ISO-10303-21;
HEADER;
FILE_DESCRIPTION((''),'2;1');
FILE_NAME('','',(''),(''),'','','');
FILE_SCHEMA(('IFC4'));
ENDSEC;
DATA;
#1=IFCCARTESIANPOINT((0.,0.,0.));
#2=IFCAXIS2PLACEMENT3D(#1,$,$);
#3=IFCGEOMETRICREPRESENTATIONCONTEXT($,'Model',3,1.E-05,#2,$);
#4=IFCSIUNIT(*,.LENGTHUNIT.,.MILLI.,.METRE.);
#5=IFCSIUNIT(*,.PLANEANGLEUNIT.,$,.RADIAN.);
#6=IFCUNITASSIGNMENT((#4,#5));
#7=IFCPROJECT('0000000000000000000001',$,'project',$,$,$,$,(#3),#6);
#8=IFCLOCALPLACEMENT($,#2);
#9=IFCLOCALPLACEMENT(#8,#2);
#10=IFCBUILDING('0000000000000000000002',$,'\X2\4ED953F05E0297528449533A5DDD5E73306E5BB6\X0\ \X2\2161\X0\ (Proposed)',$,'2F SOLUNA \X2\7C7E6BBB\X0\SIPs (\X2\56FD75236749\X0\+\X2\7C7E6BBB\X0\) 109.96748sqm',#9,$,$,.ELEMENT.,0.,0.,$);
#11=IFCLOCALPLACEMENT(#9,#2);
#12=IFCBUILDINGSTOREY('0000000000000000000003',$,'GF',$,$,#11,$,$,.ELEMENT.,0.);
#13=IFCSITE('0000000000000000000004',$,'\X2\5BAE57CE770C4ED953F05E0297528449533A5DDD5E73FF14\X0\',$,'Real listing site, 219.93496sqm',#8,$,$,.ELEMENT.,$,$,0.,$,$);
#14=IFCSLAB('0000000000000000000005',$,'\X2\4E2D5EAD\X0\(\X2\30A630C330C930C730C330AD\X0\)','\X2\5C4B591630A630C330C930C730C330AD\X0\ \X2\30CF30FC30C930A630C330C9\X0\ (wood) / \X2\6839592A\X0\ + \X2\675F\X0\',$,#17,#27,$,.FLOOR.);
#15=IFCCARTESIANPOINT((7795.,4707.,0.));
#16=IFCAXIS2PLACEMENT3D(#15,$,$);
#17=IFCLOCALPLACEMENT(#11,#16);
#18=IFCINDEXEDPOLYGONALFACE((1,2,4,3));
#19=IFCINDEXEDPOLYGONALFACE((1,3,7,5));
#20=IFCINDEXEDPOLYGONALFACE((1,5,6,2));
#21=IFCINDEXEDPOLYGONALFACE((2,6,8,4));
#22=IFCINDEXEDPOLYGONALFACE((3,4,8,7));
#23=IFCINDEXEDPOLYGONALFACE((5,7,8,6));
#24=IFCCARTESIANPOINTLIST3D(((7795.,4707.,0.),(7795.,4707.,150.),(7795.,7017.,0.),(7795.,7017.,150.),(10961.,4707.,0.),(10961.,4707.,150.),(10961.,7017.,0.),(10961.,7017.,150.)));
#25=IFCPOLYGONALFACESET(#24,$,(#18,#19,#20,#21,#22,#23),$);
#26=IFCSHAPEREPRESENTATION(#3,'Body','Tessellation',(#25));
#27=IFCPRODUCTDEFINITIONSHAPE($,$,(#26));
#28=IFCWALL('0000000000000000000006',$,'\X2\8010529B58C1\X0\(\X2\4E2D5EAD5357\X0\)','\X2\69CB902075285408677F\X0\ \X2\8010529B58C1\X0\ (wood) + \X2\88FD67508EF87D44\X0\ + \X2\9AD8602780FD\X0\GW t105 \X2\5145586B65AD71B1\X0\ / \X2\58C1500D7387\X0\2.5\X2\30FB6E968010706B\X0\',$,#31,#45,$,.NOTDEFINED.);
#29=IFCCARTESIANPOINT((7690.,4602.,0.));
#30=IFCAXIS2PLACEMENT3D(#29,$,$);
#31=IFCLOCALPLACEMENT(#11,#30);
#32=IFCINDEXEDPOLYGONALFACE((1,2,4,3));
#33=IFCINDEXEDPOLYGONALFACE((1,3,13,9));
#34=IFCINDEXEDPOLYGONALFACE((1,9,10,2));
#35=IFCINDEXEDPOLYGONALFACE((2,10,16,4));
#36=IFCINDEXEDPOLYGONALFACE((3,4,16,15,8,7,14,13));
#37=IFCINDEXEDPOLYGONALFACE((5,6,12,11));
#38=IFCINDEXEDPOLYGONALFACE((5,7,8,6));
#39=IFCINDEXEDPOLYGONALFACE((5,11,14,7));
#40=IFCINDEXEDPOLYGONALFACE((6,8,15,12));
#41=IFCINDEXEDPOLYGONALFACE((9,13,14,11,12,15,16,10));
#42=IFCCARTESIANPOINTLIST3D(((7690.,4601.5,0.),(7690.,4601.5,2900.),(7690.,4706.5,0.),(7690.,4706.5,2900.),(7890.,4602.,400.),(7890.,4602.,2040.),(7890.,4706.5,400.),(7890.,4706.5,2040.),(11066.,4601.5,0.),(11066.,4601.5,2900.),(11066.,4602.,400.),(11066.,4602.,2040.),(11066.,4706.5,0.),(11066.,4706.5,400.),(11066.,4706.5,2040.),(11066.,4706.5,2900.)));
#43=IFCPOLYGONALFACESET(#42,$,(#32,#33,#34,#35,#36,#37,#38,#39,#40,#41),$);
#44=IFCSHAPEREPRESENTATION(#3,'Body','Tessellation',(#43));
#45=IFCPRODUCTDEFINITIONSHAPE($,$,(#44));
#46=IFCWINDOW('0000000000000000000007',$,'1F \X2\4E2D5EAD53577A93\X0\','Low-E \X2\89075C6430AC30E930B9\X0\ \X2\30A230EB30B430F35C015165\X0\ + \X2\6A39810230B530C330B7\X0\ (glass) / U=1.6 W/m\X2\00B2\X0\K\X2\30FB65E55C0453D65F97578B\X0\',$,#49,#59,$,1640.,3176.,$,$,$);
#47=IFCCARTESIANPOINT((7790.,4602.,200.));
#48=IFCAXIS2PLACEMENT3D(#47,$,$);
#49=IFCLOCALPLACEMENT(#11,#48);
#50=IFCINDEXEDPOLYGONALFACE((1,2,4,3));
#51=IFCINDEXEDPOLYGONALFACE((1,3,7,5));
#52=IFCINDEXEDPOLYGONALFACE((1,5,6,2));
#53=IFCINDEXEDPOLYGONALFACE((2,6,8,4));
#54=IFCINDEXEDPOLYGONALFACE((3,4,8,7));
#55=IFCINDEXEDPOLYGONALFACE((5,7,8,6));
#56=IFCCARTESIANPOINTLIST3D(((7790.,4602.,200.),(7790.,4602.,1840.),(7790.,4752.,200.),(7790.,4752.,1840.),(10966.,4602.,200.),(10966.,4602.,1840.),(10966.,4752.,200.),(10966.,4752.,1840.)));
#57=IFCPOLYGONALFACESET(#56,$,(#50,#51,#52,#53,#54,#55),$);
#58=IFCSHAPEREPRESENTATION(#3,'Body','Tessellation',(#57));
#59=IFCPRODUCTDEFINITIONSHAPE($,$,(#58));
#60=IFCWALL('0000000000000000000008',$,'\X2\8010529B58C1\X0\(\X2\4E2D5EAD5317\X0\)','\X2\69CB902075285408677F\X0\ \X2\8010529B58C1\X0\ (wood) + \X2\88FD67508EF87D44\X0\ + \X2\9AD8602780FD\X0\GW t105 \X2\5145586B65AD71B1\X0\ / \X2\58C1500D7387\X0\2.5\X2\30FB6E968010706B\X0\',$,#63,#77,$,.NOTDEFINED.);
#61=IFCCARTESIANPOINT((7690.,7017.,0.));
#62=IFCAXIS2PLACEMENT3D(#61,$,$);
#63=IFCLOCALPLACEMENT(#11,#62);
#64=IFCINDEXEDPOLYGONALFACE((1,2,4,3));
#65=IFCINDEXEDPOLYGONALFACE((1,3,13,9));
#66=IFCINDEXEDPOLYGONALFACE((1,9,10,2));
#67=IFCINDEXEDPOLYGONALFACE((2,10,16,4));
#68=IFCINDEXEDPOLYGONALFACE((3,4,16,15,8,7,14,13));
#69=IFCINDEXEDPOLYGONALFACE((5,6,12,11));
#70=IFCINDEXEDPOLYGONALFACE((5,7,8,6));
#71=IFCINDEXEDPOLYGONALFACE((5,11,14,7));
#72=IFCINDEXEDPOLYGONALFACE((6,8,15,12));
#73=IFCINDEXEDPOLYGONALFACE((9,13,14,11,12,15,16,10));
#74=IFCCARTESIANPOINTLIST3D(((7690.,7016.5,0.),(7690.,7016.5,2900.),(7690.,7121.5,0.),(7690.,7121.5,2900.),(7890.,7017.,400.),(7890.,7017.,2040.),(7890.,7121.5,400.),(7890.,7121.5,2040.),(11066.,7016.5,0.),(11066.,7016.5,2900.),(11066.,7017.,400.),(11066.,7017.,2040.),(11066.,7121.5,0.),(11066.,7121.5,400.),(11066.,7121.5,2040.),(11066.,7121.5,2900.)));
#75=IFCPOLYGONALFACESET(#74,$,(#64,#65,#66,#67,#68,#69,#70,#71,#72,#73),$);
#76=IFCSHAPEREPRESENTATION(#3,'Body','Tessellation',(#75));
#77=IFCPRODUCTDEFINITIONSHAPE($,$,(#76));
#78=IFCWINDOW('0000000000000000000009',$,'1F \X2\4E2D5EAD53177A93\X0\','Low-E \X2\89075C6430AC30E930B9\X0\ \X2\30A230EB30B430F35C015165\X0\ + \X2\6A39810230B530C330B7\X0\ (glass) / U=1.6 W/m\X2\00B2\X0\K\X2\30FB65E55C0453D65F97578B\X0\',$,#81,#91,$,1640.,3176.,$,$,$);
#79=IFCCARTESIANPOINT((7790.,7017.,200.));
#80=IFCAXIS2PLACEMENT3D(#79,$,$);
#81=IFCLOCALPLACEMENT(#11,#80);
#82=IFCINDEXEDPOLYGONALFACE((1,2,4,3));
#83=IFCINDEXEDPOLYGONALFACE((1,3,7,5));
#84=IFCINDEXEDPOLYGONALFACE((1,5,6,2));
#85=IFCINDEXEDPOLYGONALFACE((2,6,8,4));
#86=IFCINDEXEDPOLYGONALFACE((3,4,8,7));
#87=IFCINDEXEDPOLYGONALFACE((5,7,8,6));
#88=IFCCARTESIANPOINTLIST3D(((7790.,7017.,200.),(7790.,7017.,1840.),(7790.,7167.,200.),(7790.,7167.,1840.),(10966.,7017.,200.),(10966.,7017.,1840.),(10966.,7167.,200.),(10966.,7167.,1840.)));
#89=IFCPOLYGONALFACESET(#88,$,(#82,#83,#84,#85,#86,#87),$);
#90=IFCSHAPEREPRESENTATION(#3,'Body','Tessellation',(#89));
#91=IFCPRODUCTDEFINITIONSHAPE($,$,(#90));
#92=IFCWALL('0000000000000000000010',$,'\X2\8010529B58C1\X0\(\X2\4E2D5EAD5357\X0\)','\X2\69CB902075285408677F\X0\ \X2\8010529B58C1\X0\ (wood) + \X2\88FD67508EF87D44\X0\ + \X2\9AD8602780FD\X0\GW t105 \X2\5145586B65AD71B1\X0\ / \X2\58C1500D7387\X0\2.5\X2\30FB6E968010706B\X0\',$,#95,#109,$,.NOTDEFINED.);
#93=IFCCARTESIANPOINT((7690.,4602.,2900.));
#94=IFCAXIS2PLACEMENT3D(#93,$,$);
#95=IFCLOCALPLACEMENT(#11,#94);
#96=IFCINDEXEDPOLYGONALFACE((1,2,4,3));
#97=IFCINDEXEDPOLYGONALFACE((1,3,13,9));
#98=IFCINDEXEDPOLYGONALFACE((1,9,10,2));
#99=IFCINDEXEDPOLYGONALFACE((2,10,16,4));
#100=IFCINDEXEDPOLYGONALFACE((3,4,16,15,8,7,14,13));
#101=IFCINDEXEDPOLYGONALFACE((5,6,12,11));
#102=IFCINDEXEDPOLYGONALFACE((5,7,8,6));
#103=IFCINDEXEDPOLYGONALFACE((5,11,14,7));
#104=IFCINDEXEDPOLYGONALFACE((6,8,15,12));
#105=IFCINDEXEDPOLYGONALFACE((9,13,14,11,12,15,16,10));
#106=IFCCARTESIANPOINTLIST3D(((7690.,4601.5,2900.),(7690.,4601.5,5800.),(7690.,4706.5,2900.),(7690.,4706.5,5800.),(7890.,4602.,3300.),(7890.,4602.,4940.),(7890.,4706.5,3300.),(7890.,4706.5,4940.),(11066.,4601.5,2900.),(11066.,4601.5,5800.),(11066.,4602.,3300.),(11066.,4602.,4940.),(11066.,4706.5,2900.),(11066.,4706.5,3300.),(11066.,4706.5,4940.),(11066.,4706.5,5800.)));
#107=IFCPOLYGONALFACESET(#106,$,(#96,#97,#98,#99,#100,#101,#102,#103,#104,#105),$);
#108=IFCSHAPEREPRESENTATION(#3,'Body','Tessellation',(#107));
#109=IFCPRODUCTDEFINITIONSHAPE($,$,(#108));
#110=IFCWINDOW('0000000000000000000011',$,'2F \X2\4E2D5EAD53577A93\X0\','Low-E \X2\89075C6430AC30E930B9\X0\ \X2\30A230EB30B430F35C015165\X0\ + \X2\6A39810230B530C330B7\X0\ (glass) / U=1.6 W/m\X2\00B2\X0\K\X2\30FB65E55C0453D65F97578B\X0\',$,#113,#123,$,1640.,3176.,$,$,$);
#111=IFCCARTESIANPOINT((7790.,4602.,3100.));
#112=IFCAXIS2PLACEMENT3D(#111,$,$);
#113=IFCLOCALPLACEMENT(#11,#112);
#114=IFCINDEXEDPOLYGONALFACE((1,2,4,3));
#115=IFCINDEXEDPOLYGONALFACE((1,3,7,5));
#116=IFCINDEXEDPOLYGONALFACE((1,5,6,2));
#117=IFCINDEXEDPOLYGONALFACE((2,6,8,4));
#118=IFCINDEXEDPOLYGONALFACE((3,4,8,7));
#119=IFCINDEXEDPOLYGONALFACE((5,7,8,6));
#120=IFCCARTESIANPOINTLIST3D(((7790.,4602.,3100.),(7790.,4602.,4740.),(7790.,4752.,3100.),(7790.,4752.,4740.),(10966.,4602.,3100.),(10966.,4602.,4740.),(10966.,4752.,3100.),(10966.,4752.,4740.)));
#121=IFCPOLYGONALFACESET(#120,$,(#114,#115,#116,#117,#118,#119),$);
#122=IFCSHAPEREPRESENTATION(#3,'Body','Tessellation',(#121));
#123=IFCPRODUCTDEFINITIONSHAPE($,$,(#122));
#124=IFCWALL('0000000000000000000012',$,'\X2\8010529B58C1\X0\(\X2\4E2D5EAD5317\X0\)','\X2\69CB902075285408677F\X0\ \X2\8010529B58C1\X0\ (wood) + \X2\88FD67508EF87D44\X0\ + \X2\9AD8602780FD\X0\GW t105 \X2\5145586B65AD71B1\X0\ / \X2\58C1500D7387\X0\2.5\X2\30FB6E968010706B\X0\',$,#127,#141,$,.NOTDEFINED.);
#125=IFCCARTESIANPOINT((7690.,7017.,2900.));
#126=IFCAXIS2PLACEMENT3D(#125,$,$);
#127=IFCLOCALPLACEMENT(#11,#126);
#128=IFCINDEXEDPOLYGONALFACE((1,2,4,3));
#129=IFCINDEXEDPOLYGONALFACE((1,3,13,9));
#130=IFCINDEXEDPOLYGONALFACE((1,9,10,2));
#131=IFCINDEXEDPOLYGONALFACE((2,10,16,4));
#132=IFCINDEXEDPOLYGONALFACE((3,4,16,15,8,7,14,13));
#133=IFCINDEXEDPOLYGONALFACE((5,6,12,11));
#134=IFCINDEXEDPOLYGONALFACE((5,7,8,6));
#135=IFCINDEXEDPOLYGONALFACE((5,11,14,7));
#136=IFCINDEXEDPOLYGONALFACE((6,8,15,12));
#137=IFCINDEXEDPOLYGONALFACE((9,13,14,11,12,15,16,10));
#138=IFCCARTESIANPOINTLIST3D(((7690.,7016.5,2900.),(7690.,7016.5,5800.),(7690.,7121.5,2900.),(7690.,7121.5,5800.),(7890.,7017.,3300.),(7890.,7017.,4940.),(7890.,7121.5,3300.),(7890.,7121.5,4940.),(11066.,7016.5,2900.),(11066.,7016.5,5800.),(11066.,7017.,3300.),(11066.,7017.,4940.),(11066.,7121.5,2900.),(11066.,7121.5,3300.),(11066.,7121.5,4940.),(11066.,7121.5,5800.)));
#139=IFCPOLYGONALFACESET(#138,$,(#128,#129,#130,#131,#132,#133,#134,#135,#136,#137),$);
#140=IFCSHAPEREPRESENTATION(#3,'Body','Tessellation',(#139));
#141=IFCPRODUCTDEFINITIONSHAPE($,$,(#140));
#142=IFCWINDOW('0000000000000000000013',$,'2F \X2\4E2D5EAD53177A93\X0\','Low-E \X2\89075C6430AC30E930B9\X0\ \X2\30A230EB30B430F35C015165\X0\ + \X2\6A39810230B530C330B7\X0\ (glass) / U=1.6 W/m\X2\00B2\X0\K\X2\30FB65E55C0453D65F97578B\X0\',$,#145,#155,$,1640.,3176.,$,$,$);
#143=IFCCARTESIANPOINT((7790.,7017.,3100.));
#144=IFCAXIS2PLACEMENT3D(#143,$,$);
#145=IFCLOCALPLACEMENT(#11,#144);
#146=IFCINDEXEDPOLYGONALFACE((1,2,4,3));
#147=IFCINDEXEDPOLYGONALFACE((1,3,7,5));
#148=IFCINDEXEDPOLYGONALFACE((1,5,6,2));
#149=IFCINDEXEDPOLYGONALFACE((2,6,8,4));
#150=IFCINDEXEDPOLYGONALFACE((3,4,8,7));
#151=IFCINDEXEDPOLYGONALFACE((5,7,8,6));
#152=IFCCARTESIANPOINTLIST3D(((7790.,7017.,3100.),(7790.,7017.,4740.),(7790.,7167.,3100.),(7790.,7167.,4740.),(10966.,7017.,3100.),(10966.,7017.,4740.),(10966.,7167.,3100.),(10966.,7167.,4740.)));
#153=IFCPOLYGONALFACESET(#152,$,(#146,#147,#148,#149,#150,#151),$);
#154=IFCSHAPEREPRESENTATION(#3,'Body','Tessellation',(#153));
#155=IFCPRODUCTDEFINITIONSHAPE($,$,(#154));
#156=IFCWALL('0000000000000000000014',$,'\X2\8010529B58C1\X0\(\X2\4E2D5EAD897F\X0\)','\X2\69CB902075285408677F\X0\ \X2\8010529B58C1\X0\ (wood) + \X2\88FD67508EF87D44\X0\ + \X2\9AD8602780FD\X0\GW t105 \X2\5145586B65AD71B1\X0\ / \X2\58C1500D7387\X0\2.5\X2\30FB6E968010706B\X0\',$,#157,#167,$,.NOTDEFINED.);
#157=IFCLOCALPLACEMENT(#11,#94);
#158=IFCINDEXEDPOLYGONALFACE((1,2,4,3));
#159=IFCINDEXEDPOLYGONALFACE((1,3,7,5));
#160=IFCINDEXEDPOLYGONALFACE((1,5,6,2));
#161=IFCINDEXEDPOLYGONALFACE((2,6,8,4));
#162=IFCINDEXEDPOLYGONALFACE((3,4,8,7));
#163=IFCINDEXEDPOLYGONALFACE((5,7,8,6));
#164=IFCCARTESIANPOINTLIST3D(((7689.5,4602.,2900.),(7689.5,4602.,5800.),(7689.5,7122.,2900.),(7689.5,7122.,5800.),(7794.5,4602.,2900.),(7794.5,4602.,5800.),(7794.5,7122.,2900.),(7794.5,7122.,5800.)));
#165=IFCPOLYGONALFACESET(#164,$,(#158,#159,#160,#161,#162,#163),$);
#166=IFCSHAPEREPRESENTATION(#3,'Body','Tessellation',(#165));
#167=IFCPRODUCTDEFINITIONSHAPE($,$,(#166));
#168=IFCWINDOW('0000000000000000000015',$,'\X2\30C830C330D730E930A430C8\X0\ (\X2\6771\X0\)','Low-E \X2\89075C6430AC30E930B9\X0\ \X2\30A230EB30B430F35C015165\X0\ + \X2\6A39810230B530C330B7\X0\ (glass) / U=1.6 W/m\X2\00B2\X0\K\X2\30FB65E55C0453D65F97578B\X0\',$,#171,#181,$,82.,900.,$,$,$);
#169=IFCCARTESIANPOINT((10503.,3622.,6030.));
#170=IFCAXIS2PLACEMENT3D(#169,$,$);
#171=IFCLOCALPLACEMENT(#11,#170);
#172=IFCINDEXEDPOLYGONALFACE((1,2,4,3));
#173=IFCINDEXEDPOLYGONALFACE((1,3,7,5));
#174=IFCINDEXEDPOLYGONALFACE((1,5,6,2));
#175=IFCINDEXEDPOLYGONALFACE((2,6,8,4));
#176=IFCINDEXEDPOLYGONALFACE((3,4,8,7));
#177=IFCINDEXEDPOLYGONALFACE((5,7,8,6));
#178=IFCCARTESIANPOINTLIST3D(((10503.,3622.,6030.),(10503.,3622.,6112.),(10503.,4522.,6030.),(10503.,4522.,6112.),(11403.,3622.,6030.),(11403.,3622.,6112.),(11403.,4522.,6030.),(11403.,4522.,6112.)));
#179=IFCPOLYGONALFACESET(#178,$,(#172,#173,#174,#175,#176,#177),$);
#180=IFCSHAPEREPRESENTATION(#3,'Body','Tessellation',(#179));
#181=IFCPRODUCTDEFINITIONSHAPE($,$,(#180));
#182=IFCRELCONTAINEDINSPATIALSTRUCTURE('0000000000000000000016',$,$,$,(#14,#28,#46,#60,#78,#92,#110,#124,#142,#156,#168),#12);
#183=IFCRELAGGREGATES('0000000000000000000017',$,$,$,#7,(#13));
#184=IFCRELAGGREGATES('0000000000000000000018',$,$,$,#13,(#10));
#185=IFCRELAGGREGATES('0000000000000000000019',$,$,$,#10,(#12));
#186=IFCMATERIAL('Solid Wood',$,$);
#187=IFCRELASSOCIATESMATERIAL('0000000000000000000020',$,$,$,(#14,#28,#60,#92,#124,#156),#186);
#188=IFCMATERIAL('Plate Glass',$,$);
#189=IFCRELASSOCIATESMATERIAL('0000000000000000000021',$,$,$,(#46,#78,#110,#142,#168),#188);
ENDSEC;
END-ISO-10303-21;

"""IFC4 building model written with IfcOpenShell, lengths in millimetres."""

from ifc_helpers import new_model, si_unit, frame, frame_2d, origin, place, context, project, spatial, rectangle, extrude, material, element, fill, save


model = new_model("IFC4")

# Units and contexts
model_context = context("Model", 3, precision=1e-05, world=origin())
ifc_project = project(units=[si_unit("LENGTHUNIT", "METRE", prefix="MILLI"), si_unit("PLANEANGLEUNIT", "RADIAN")], contexts=[model_context])

# Site, building, storey
site_placement = place(None, origin())
site = spatial("IfcSite", under=ifc_project, at=site_placement, Name="宮城県仙台市青葉区川平４", ObjectType="Real listing site, 219.93496sqm", CompositionType="ELEMENT", RefElevation=0.0)
building_placement = place(site_placement, origin())
building = spatial("IfcBuilding", under=site, at=building_placement, Name="仙台市青葉区川平の家 Ⅱ (Proposed)", ObjectType="2F SOLUNA 籾殻SIPs (国産杉+籾殻) 109.96748sqm", CompositionType="ELEMENT", ElevationOfRefHeight=0.0, ElevationOfTerrain=0.0)
storey_placement = place(building_placement, origin())
storey = spatial("IfcBuildingStorey", under=building, at=storey_placement, Name="GF", CompositionType="ELEMENT", Elevation=0.0)

# Slab
ifc_material_1 = material(Name="Solid Wood")
slab_placement = place(storey_placement, frame((7795.0, 4707.0, 0.0)))
element("IfcSlab", 1, at=slab_placement, inside=storey, material=ifc_material_1, Name="中庭(ウッドデッキ)", Description="屋外ウッドデッキ ハードウッド (wood) / 根太 + 束", PredefinedType="FLOOR", context=model_context, shape_type="SweptSolid", body=[
    extrude(rectangle(XDim=3166.0, YDim=2310.0, at=frame_2d((1583.0, 1155.0))), frame((7795.0, 4707.0, 0.0)), (0.0, 0.0, 1.0), 150.0),
])

# Walls, openings, windows
wall_1_placement = place(storey_placement, frame((7690.0, 4602.0, 0.0)))
wall_1 = element("IfcWall", 2, at=wall_1_placement, inside=storey, material=ifc_material_1, Name="耐力壁(中庭南)", Description="構造用合板 耐力壁 (wood) + 製材軸組 + 高性能GW t105 充填断熱 / 壁倍率2.5・準耐火", PredefinedType="NOTDEFINED", context=model_context, shape_type="SweptSolid", body=[
    extrude(rectangle(XDim=3376.0, YDim=105.0, at=frame_2d((1688.0, 52.0))), frame((7690.0, 4602.0, 0.0)), (0.0, 0.0, 1.0), 2900.0),
])
opening_1_placement = place(storey_placement, frame((7790.0, 4602.0, 200.0)))
opening_1 = element("IfcOpeningElement", 3, at=opening_1_placement, cuts=wall_1, PredefinedType="NOTDEFINED", context=model_context, shape_type="SweptSolid", body=[
    extrude(rectangle(XDim=3176.0, YDim=150.0, at=frame_2d((1588.0, 75.0))), frame((7790.0, 4602.0, 200.0)), (0.0, 0.0, 1.0), 1640.0),
])
ifc_material_2 = material(Name="Plate Glass")
window_1_placement = place(storey_placement, frame((7790.0, 4602.0, 200.0)))
window_1 = element("IfcWindow", 4, at=window_1_placement, inside=storey, material=ifc_material_2, Name="1F 中庭南窓", Description="Low-E 複層ガラス アルゴン封入 + 樹脂サッシ (glass) / U=1.6 W/m²K・日射取得型", OverallHeight=1640.0, OverallWidth=3176.0, context=model_context, shape_type="SweptSolid", body=[
    extrude(rectangle(XDim=3176.0, YDim=150.0, at=frame_2d((1588.0, 75.0))), frame((7790.0, 4602.0, 200.0)), (0.0, 0.0, 1.0), 1640.0),
])
fill(opening_1, window_1)
wall_2_placement = place(storey_placement, frame((7690.0, 7017.0, 0.0)))
wall_2 = element("IfcWall", 5, at=wall_2_placement, inside=storey, material=ifc_material_1, Name="耐力壁(中庭北)", Description="構造用合板 耐力壁 (wood) + 製材軸組 + 高性能GW t105 充填断熱 / 壁倍率2.5・準耐火", PredefinedType="NOTDEFINED", context=model_context, shape_type="SweptSolid", body=[
    extrude(rectangle(XDim=3376.0, YDim=105.0, at=frame_2d((1688.0, 52.0))), frame((7690.0, 7017.0, 0.0)), (0.0, 0.0, 1.0), 2900.0),
])
opening_2_placement = place(storey_placement, frame((7790.0, 7017.0, 200.0)))
opening_2 = element("IfcOpeningElement", 6, at=opening_2_placement, cuts=wall_2, PredefinedType="NOTDEFINED", context=model_context, shape_type="SweptSolid", body=[
    extrude(rectangle(XDim=3176.0, YDim=150.0, at=frame_2d((1588.0, 75.0))), frame((7790.0, 7017.0, 200.0)), (0.0, 0.0, 1.0), 1640.0),
])
window_2_placement = place(storey_placement, frame((7790.0, 7017.0, 200.0)))
window_2 = element("IfcWindow", 7, at=window_2_placement, inside=storey, material=ifc_material_2, Name="1F 中庭北窓", Description="Low-E 複層ガラス アルゴン封入 + 樹脂サッシ (glass) / U=1.6 W/m²K・日射取得型", OverallHeight=1640.0, OverallWidth=3176.0, context=model_context, shape_type="SweptSolid", body=[
    extrude(rectangle(XDim=3176.0, YDim=150.0, at=frame_2d((1588.0, 75.0))), frame((7790.0, 7017.0, 200.0)), (0.0, 0.0, 1.0), 1640.0),
])
fill(opening_2, window_2)

# Walls, openings, windows
wall_3_placement = place(storey_placement, frame((7690.0, 4602.0, 2900.0)))
wall_3 = element("IfcWall", 8, at=wall_3_placement, inside=storey, material=ifc_material_1, Name="耐力壁(中庭南)", Description="構造用合板 耐力壁 (wood) + 製材軸組 + 高性能GW t105 充填断熱 / 壁倍率2.5・準耐火", PredefinedType="NOTDEFINED", context=model_context, shape_type="SweptSolid", body=[
    extrude(rectangle(XDim=3376.0, YDim=105.0, at=frame_2d((1688.0, 52.0))), frame((7690.0, 4602.0, 2900.0)), (0.0, 0.0, 1.0), 2900.0),
])
opening_3_placement = place(storey_placement, frame((7790.0, 4602.0, 3100.0)))
opening_3 = element("IfcOpeningElement", 9, at=opening_3_placement, cuts=wall_3, PredefinedType="NOTDEFINED", context=model_context, shape_type="SweptSolid", body=[
    extrude(rectangle(XDim=3176.0, YDim=150.0, at=frame_2d((1588.0, 75.0))), frame((7790.0, 4602.0, 3100.0)), (0.0, 0.0, 1.0), 1640.0),
])
window_3_placement = place(storey_placement, frame((7790.0, 4602.0, 3100.0)))
window_3 = element("IfcWindow", 10, at=window_3_placement, inside=storey, material=ifc_material_2, Name="2F 中庭南窓", Description="Low-E 複層ガラス アルゴン封入 + 樹脂サッシ (glass) / U=1.6 W/m²K・日射取得型", OverallHeight=1640.0, OverallWidth=3176.0, context=model_context, shape_type="SweptSolid", body=[
    extrude(rectangle(XDim=3176.0, YDim=150.0, at=frame_2d((1588.0, 75.0))), frame((7790.0, 4602.0, 3100.0)), (0.0, 0.0, 1.0), 1640.0),
])
fill(opening_3, window_3)
wall_4_placement = place(storey_placement, frame((7690.0, 7017.0, 2900.0)))
wall_4 = element("IfcWall", 11, at=wall_4_placement, inside=storey, material=ifc_material_1, Name="耐力壁(中庭北)", Description="構造用合板 耐力壁 (wood) + 製材軸組 + 高性能GW t105 充填断熱 / 壁倍率2.5・準耐火", PredefinedType="NOTDEFINED", context=model_context, shape_type="SweptSolid", body=[
    extrude(rectangle(XDim=3376.0, YDim=105.0, at=frame_2d((1688.0, 52.0))), frame((7690.0, 7017.0, 2900.0)), (0.0, 0.0, 1.0), 2900.0),
])
opening_4_placement = place(storey_placement, frame((7790.0, 7017.0, 3100.0)))
opening_4 = element("IfcOpeningElement", 12, at=opening_4_placement, cuts=wall_4, PredefinedType="NOTDEFINED", context=model_context, shape_type="SweptSolid", body=[
    extrude(rectangle(XDim=3176.0, YDim=150.0, at=frame_2d((1588.0, 75.0))), frame((7790.0, 7017.0, 3100.0)), (0.0, 0.0, 1.0), 1640.0),
])
window_4_placement = place(storey_placement, frame((7790.0, 7017.0, 3100.0)))
window_4 = element("IfcWindow", 13, at=window_4_placement, inside=storey, material=ifc_material_2, Name="2F 中庭北窓", Description="Low-E 複層ガラス アルゴン封入 + 樹脂サッシ (glass) / U=1.6 W/m²K・日射取得型", OverallHeight=1640.0, OverallWidth=3176.0, context=model_context, shape_type="SweptSolid", body=[
    extrude(rectangle(XDim=3176.0, YDim=150.0, at=frame_2d((1588.0, 75.0))), frame((7790.0, 7017.0, 3100.0)), (0.0, 0.0, 1.0), 1640.0),
])
fill(opening_4, window_4)

# Wall
wall_5_placement = place(storey_placement, frame((7690.0, 4602.0, 2900.0)))
element("IfcWall", 14, at=wall_5_placement, inside=storey, material=ifc_material_1, Name="耐力壁(中庭西)", Description="構造用合板 耐力壁 (wood) + 製材軸組 + 高性能GW t105 充填断熱 / 壁倍率2.5・準耐火", PredefinedType="NOTDEFINED", context=model_context, shape_type="SweptSolid", body=[
    extrude(rectangle(XDim=105.0, YDim=2520.0, at=frame_2d((52.0, 1260.0))), frame((7690.0, 4602.0, 2900.0)), (0.0, 0.0, 1.0), 2900.0),
])

# Window
window_5_placement = place(storey_placement, frame((10503.0, 3622.0, 6030.0)))
element("IfcWindow", 15, at=window_5_placement, inside=storey, material=ifc_material_2, Name="トップライト (東)", Description="Low-E 複層ガラス アルゴン封入 + 樹脂サッシ (glass) / U=1.6 W/m²K・日射取得型", OverallHeight=82.0, OverallWidth=900.0, context=model_context, shape_type="SweptSolid", body=[
    extrude(rectangle(XDim=900.0, YDim=900.0, at=frame_2d((450.0, 450.0))), frame((10503.0, 3622.0, 6030.0)), (0.0, 0.0, 1.0), 82.0),
])

save(model, "model.ifc")
